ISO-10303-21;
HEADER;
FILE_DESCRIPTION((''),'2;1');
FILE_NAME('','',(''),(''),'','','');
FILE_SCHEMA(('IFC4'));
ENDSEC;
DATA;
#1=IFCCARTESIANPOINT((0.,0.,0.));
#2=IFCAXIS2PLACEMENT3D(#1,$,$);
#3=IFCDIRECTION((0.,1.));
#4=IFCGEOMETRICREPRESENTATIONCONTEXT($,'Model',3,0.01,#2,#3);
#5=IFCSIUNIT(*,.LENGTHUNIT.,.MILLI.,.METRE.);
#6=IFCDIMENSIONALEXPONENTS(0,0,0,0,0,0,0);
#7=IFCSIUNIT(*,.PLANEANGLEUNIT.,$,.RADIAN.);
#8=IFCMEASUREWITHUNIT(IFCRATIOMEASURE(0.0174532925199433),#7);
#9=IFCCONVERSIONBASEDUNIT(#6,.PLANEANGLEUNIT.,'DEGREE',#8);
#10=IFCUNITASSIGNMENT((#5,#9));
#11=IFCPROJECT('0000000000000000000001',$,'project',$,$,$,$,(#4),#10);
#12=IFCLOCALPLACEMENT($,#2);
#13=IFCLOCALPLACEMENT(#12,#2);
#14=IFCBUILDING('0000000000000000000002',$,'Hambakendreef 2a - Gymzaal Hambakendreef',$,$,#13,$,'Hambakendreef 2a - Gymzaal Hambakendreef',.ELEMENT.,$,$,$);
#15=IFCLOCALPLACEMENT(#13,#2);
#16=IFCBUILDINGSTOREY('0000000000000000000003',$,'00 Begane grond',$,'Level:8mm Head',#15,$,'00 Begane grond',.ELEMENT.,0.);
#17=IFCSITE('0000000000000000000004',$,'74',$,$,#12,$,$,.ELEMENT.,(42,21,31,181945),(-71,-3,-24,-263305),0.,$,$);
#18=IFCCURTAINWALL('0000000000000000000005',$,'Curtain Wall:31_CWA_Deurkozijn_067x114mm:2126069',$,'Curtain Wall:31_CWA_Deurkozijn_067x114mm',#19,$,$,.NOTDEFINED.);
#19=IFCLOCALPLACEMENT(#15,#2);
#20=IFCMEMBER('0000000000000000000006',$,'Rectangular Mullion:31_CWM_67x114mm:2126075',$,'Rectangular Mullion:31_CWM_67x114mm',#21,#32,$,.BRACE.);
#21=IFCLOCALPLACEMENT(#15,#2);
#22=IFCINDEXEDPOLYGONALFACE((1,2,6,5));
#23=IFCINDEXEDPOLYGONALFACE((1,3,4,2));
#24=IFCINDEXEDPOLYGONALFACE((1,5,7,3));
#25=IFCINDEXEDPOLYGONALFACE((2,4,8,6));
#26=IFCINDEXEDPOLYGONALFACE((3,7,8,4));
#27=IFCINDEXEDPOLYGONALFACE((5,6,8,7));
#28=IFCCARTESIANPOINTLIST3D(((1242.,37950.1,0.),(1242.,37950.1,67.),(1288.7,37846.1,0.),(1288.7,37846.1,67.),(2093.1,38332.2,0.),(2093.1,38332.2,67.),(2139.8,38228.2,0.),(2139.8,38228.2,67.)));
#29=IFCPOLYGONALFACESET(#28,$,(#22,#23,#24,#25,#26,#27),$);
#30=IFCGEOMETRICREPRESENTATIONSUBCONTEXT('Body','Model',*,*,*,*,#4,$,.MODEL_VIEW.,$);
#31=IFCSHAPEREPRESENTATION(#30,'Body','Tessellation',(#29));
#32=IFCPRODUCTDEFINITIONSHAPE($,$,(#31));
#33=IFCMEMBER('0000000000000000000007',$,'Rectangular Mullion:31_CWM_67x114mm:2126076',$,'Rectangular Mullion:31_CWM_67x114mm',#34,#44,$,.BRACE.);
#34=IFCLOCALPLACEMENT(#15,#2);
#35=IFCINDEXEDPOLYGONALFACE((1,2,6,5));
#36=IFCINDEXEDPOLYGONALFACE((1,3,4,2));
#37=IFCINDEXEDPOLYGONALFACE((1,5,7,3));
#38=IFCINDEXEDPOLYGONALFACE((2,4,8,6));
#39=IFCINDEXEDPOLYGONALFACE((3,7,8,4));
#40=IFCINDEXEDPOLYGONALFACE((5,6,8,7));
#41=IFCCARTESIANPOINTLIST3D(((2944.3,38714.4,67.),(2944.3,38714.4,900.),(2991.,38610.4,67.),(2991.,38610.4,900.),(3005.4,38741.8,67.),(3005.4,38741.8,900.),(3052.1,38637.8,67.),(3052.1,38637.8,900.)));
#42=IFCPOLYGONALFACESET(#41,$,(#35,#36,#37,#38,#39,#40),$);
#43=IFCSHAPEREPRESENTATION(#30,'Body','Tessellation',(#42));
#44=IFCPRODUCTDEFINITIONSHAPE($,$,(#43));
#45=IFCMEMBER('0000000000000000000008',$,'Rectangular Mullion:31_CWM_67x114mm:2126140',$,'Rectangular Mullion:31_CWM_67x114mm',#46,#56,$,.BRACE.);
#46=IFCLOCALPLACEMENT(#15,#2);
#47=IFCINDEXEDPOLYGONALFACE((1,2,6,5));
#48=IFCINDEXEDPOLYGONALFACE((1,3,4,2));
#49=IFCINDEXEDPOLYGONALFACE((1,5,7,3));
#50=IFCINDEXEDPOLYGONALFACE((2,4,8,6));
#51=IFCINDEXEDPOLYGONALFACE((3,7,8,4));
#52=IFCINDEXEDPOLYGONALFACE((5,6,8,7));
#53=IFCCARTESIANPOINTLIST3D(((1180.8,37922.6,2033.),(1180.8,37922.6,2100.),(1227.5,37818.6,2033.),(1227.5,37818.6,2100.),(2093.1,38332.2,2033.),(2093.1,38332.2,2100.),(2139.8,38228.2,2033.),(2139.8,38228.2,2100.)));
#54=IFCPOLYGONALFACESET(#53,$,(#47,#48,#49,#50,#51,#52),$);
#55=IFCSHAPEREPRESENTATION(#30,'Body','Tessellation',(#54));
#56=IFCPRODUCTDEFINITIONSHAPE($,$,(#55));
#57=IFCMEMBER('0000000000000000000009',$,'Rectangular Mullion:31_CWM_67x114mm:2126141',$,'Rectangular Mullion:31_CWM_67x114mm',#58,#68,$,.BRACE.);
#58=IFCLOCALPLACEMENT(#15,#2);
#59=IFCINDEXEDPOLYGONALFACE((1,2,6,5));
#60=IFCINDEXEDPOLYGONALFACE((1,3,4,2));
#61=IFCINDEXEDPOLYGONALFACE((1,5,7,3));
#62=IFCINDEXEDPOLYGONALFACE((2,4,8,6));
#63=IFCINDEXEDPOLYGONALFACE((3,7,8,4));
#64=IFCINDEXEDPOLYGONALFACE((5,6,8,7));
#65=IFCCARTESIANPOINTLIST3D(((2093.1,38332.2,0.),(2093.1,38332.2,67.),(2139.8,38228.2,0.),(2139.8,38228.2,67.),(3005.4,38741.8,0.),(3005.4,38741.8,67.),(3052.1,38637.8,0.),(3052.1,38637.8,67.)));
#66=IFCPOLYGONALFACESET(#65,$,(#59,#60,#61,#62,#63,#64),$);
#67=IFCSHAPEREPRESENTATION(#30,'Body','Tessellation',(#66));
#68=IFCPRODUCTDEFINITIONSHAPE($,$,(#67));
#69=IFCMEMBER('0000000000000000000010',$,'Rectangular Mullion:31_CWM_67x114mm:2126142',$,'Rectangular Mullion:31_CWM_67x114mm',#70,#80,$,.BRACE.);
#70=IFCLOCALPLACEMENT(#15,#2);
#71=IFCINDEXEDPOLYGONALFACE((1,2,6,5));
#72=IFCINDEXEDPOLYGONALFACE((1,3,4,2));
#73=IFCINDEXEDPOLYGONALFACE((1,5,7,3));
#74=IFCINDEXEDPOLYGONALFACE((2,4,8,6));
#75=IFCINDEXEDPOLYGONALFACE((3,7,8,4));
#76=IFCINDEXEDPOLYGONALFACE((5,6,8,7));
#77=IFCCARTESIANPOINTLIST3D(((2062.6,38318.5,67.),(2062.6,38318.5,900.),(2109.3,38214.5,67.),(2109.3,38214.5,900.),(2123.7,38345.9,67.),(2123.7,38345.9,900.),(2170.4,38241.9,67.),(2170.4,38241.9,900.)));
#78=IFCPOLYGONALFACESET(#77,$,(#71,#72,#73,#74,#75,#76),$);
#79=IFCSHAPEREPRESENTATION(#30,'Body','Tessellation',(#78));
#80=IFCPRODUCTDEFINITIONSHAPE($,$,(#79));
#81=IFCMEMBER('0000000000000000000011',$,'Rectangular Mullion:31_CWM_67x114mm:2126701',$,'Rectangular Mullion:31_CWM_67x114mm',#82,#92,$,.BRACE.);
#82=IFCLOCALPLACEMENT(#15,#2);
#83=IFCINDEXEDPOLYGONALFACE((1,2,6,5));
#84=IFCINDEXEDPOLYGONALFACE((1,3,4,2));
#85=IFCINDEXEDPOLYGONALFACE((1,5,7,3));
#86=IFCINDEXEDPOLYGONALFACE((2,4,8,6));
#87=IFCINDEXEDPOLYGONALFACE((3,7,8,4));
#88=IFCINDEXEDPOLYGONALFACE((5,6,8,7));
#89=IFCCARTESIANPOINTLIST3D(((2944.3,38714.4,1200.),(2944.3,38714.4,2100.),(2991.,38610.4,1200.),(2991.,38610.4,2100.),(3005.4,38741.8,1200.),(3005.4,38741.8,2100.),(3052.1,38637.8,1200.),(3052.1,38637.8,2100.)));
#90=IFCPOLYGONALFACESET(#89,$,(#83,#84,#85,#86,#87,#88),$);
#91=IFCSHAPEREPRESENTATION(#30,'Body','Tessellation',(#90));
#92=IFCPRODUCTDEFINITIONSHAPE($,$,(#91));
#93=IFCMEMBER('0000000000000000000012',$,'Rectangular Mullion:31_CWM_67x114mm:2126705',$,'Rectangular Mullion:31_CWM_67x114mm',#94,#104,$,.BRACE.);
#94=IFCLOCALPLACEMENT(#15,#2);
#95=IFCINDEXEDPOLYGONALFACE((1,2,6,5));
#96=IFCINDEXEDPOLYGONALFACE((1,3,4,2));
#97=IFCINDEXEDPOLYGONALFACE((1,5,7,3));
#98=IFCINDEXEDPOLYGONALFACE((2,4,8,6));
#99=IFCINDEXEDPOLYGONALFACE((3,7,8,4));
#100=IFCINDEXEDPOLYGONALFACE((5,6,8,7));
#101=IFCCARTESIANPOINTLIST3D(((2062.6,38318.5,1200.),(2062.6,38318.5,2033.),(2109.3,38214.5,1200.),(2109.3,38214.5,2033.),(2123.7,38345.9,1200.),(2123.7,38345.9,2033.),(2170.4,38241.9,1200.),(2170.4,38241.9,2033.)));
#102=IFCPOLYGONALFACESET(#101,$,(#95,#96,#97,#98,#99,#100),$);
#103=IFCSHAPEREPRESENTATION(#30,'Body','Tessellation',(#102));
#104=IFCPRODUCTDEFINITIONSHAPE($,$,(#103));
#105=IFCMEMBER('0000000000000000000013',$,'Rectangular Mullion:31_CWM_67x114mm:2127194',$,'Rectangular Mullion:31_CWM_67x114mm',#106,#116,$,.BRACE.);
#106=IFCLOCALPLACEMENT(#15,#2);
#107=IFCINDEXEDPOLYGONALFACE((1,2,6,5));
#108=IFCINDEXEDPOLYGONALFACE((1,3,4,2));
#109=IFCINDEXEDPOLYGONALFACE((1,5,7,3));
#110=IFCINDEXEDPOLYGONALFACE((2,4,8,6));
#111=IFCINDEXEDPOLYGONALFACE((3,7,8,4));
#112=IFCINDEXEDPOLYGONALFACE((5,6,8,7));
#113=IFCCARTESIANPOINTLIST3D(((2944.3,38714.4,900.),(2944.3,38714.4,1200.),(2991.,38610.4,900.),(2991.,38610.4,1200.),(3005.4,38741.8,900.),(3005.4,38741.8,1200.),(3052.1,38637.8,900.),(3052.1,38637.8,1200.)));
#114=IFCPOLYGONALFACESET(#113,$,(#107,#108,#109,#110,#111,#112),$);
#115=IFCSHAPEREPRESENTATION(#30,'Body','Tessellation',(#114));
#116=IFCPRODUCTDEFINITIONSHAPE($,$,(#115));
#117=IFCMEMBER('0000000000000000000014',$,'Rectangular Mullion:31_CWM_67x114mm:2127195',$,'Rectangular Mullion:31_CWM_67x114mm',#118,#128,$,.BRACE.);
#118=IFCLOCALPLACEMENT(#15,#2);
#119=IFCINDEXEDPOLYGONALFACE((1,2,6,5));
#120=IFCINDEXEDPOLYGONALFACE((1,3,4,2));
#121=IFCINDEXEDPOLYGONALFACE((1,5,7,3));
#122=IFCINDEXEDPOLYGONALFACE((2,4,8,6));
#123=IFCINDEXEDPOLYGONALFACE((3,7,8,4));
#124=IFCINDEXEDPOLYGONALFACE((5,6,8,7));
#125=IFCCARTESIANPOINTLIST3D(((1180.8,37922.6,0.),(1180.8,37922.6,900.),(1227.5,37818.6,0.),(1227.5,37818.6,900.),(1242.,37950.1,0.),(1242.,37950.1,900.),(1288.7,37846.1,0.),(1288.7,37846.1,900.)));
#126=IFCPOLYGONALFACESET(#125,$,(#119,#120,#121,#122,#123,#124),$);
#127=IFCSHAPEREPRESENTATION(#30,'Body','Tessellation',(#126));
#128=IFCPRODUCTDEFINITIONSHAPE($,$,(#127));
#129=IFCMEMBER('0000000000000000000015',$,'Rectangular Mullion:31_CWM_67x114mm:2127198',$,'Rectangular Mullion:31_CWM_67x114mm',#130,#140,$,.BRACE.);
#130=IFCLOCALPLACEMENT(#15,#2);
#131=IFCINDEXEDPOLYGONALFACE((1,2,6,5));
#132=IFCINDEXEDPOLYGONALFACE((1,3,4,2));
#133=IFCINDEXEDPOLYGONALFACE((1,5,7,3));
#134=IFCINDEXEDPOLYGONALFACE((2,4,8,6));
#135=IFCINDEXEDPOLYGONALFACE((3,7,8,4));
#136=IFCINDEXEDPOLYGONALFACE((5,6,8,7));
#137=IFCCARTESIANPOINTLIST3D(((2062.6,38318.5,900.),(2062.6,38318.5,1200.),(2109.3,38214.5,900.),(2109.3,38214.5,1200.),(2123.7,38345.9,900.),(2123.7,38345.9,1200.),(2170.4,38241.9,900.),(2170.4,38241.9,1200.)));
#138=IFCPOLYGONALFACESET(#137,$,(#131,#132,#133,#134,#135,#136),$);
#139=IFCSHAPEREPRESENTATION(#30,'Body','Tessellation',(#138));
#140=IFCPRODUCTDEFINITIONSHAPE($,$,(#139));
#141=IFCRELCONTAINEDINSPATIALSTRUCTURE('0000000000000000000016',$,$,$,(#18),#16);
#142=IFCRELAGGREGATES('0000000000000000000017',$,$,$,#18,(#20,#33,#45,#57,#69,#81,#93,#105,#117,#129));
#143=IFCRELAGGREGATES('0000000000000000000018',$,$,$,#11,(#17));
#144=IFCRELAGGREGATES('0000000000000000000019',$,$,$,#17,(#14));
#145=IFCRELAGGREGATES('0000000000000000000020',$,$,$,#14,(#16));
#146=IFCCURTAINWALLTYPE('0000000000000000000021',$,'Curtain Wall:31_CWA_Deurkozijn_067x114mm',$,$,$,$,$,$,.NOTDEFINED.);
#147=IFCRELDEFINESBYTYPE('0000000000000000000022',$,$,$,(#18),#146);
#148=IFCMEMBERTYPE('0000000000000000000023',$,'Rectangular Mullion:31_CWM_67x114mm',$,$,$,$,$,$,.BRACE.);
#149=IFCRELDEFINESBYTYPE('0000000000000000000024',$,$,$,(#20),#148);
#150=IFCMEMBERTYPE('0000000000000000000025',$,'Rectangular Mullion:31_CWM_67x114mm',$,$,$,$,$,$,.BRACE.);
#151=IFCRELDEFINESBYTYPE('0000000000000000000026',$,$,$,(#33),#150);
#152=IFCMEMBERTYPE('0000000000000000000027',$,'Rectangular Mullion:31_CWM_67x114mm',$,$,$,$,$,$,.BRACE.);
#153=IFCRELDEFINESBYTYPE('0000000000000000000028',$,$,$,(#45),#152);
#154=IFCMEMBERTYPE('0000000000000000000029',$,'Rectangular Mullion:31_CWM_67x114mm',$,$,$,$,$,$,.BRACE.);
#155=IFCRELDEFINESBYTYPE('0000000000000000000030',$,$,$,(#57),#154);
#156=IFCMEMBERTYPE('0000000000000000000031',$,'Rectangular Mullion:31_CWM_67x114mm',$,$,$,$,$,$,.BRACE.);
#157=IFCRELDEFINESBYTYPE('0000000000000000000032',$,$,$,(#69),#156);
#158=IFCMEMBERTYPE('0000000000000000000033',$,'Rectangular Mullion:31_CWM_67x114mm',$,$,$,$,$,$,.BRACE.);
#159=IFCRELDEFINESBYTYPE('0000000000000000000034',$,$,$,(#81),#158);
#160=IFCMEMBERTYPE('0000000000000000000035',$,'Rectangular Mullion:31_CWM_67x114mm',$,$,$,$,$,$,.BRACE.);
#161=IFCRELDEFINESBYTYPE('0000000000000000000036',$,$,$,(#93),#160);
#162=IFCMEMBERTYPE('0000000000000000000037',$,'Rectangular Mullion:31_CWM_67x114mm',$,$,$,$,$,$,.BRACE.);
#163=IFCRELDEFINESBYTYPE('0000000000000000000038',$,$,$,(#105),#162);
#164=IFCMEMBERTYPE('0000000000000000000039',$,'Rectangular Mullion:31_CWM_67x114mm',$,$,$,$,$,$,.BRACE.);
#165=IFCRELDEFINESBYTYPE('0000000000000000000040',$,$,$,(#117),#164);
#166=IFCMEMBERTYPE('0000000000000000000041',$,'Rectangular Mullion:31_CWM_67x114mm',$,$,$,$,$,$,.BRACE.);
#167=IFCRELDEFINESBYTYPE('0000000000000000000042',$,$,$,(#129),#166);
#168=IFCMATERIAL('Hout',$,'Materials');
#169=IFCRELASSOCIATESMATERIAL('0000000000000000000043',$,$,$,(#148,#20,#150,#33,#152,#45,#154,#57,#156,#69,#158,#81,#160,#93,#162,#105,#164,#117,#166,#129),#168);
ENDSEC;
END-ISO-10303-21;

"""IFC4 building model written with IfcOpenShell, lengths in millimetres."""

from ifc_helpers import new_model, entity, si_unit, converted_unit, direction, frame, origin, place, context, subcontext, project, spatial, indexed_curve, outline, extrude, source, transform, mapped, material, type_object, type_shapes, element, aggregate, save


model = new_model("IFC4")

# Units and contexts
model_context = context("Model", 3, precision=0.01, world=origin(), true_north=direction((0.0, 1.0)))
body_context = subcontext(model_context, "Body", "Model", "MODEL_VIEW")
ifc_project = project(units=[si_unit("LENGTHUNIT", "METRE", prefix="MILLI"), converted_unit("PLANEANGLEUNIT", "DEGREE", entity("IfcRatioMeasure", 0.0174532925199433), si_unit("PLANEANGLEUNIT", "RADIAN"), dimensions=[0, 0, 0, 0, 0, 0, 0])], contexts=[model_context])

# Site, building, storey
site_placement = place(None, origin())
site = spatial("IfcSite", under=ifc_project, at=site_placement, Name="74", CompositionType="ELEMENT", RefLatitude=(42, 21, 31, 181945), RefLongitude=(-71, -3, -24, -263305), RefElevation=0.0)
building_placement = place(site_placement, origin())
building = spatial("IfcBuilding", under=site, at=building_placement, Name="Hambakendreef 2a - Gymzaal Hambakendreef", LongName="Hambakendreef 2a - Gymzaal Hambakendreef", CompositionType="ELEMENT")
storey_placement = place(building_placement, origin())
storey = spatial("IfcBuildingStorey", under=building, at=storey_placement, Name="00 Begane grond", ObjectType="Level:8mm Head", LongName="00 Begane grond", CompositionType="ELEMENT", Elevation=0.0)

# Curtain wall, members
ifc_material_1 = material(Name="Hout", Category="Materials")
curtain_wall_type_1 = type_object("IfcCurtainWallType", Name="Curtain Wall:31_CWA_Deurkozijn_067x114mm", PredefinedType="NOTDEFINED")
curtain_wall_1_placement = place(storey_placement, origin())
curtain_wall_1 = element("IfcCurtainWall", 1, at=curtain_wall_1_placement, inside=storey, type_object=curtain_wall_type_1, Name="Curtain Wall:31_CWA_Deurkozijn_067x114mm:2126069", ObjectType="Curtain Wall:31_CWA_Deurkozijn_067x114mm", PredefinedType="NOTDEFINED")
member_type_1 = type_object("IfcMemberType", Name="Rectangular Mullion:31_CWM_67x114mm", PredefinedType="BRACE", material=ifc_material_1)
shared_shape_1 = source(origin(), body_context, "Body", "SweptSolid", [
    extrude(outline(indexed_curve([(-57.0, -33.5), (57.0, -33.5), (57.0, 33.5), (-57.0, 33.5), (-57.0, -33.5)], self_intersect=False)), frame((-33.5, 0.0, -933.0), z_axis=(0.0, 0.0, 1.0), x_axis=(0.0, -1.0, 0.0)), (0.0, 0.0, 1.0), 933.0),
])
type_shapes(member_type_1, [shared_shape_1])
member_1_placement = place(storey_placement, frame((1265.3, 37898.1, 0.0), z_axis=(-0.91227, -0.40959, 0.0), x_axis=(0.0, 0.0, -1.0)))
member_1 = element("IfcMember", 2, at=member_1_placement, type_object=member_type_1, material=ifc_material_1, Name="Rectangular Mullion:31_CWM_67x114mm:2126075", ObjectType="Rectangular Mullion:31_CWM_67x114mm", PredefinedType="BRACE", context=body_context, shape_type="MappedRepresentation", body=[
    mapped(shared_shape_1, transform((0.0, 0.0, 0.0), scale=1.0)),
])
member_type_2 = type_object("IfcMemberType", Name="Rectangular Mullion:31_CWM_67x114mm", PredefinedType="BRACE", material=ifc_material_1)
shared_shape_2 = source(origin(), body_context, "Body", "SweptSolid", [
    extrude(outline(indexed_curve([(-57.0, -33.5), (57.0, -33.5), (57.0, 33.5), (-57.0, 33.5), (-57.0, -33.5)], self_intersect=False)), frame((-33.5, 0.0, -833.0), z_axis=(0.0, 0.0, 1.0), x_axis=(0.0, -1.0, 0.0)), (0.0, 0.0, 1.0), 833.0),
])
type_shapes(member_type_2, [shared_shape_2])
member_2_placement = place(storey_placement, frame((3028.7, 38689.8, 67.0), z_axis=(0.0, 0.0, -1.0), x_axis=(0.91227, 0.40959, 0.0)))
member_2 = element("IfcMember", 3, at=member_2_placement, type_object=member_type_2, material=ifc_material_1, Name="Rectangular Mullion:31_CWM_67x114mm:2126076", ObjectType="Rectangular Mullion:31_CWM_67x114mm", PredefinedType="BRACE", context=body_context, shape_type="MappedRepresentation", body=[
    mapped(shared_shape_2, transform((0.0, 0.0, 0.0), scale=1.0)),
])
member_type_3 = type_object("IfcMemberType", Name="Rectangular Mullion:31_CWM_67x114mm", PredefinedType="BRACE", material=ifc_material_1)
shared_shape_3 = source(origin(), body_context, "Body", "SweptSolid", [
    extrude(outline(indexed_curve([(-57.0, -33.5), (57.0, -33.5), (57.0, 33.5), (-57.0, 33.5), (-57.0, -33.5)], self_intersect=False)), frame((-33.5, 0.0, -1000.0), z_axis=(0.0, 0.0, 1.0), x_axis=(0.0, -1.0, 0.0)), (0.0, 0.0, 1.0), 1000.0),
])
type_shapes(member_type_3, [shared_shape_3])
member_3_placement = place(storey_placement, frame((2116.5, 38280.2, 2100.0), z_axis=(0.91227, 0.40959, 0.0), x_axis=(0.0, 0.0, 1.0)))
member_3 = element("IfcMember", 4, at=member_3_placement, type_object=member_type_3, material=ifc_material_1, Name="Rectangular Mullion:31_CWM_67x114mm:2126140", ObjectType="Rectangular Mullion:31_CWM_67x114mm", PredefinedType="BRACE", context=body_context, shape_type="MappedRepresentation", body=[
    mapped(shared_shape_3, transform((0.0, 0.0, 0.0), scale=1.0)),
])
member_type_4 = type_object("IfcMemberType", Name="Rectangular Mullion:31_CWM_67x114mm", PredefinedType="BRACE", material=ifc_material_1)
shared_shape_4 = source(origin(), body_context, "Body", "SweptSolid", [
    extrude(outline(indexed_curve([(-57.0, -33.5), (57.0, -33.5), (57.0, 33.5), (-57.0, 33.5), (-57.0, -33.5)], self_intersect=False)), frame((-33.5, 0.0, -1000.0), z_axis=(0.0, 0.0, 1.0), x_axis=(0.0, -1.0, 0.0)), (0.0, 0.0, 1.0), 1000.0),
])
type_shapes(member_type_4, [shared_shape_4])
member_4_placement = place(storey_placement, frame((2116.5, 38280.2, 0.0), z_axis=(-0.91227, -0.40959, 0.0), x_axis=(0.0, 0.0, -1.0)))
member_4 = element("IfcMember", 5, at=member_4_placement, type_object=member_type_4, material=ifc_material_1, Name="Rectangular Mullion:31_CWM_67x114mm:2126141", ObjectType="Rectangular Mullion:31_CWM_67x114mm", PredefinedType="BRACE", context=body_context, shape_type="MappedRepresentation", body=[
    mapped(shared_shape_4, transform((0.0, 0.0, 0.0), scale=1.0)),
])
member_type_5 = type_object("IfcMemberType", Name="Rectangular Mullion:31_CWM_67x114mm", PredefinedType="BRACE", material=ifc_material_1)
shared_shape_5 = source(origin(), body_context, "Body", "SweptSolid", [
    extrude(outline(indexed_curve([(-57.0, -33.5), (57.0, -33.5), (57.0, 33.5), (-57.0, 33.5), (-57.0, -33.5)], self_intersect=False)), frame((0.0, 0.0, -833.0), z_axis=(0.0, 0.0, 1.0), x_axis=(0.0, -1.0, 0.0)), (0.0, 0.0, 1.0), 833.0),
])
type_shapes(member_type_5, [shared_shape_5])
member_5_placement = place(storey_placement, frame((2116.5, 38280.2, 67.0), z_axis=(0.0, 0.0, -1.0), x_axis=(0.91227, 0.40959, 0.0)))
member_5 = element("IfcMember", 6, at=member_5_placement, type_object=member_type_5, material=ifc_material_1, Name="Rectangular Mullion:31_CWM_67x114mm:2126142", ObjectType="Rectangular Mullion:31_CWM_67x114mm", PredefinedType="BRACE", context=body_context, shape_type="MappedRepresentation", body=[
    mapped(shared_shape_5, transform((0.0, 0.0, 0.0), scale=1.0)),
])
member_type_6 = type_object("IfcMemberType", Name="Rectangular Mullion:31_CWM_67x114mm", PredefinedType="BRACE", material=ifc_material_1)
shared_shape_6 = source(origin(), body_context, "Body", "SweptSolid", [
    extrude(outline(indexed_curve([(-57.0, -33.5), (57.0, -33.5), (57.0, 33.5), (-57.0, 33.5), (-57.0, -33.5)], self_intersect=False)), frame((-33.5, 0.0, -900.0), z_axis=(0.0, 0.0, 1.0), x_axis=(0.0, -1.0, 0.0)), (0.0, 0.0, 1.0), 900.0),
])
type_shapes(member_type_6, [shared_shape_6])
member_6_placement = place(storey_placement, frame((3028.7, 38689.8, 1200.0), z_axis=(0.0, 0.0, -1.0), x_axis=(0.91227, 0.40959, 0.0)))
member_6 = element("IfcMember", 7, at=member_6_placement, type_object=member_type_6, material=ifc_material_1, Name="Rectangular Mullion:31_CWM_67x114mm:2126701", ObjectType="Rectangular Mullion:31_CWM_67x114mm", PredefinedType="BRACE", context=body_context, shape_type="MappedRepresentation", body=[
    mapped(shared_shape_6, transform((0.0, 0.0, 0.0), scale=1.0)),
])
member_type_7 = type_object("IfcMemberType", Name="Rectangular Mullion:31_CWM_67x114mm", PredefinedType="BRACE", material=ifc_material_1)
shared_shape_7 = source(origin(), body_context, "Body", "SweptSolid", [
    extrude(outline(indexed_curve([(-57.0, -33.5), (57.0, -33.5), (57.0, 33.5), (-57.0, 33.5), (-57.0, -33.5)], self_intersect=False)), frame((0.0, 0.0, -833.0), z_axis=(0.0, 0.0, 1.0), x_axis=(0.0, -1.0, 0.0)), (0.0, 0.0, 1.0), 833.0),
])
type_shapes(member_type_7, [shared_shape_7])
member_7_placement = place(storey_placement, frame((2116.5, 38280.2, 1200.0), z_axis=(0.0, 0.0, -1.0), x_axis=(0.91227, 0.40959, 0.0)))
member_7 = element("IfcMember", 8, at=member_7_placement, type_object=member_type_7, material=ifc_material_1, Name="Rectangular Mullion:31_CWM_67x114mm:2126705", ObjectType="Rectangular Mullion:31_CWM_67x114mm", PredefinedType="BRACE", context=body_context, shape_type="MappedRepresentation", body=[
    mapped(shared_shape_7, transform((0.0, 0.0, 0.0), scale=1.0)),
])
member_type_8 = type_object("IfcMemberType", Name="Rectangular Mullion:31_CWM_67x114mm", PredefinedType="BRACE", material=ifc_material_1)
shared_shape_8 = source(origin(), body_context, "Body", "SweptSolid", [
    extrude(outline(indexed_curve([(-57.0, -33.5), (57.0, -33.5), (57.0, 33.5), (-57.0, 33.5), (-57.0, -33.5)], self_intersect=False)), frame((-33.5, 0.0, -300.0), z_axis=(0.0, 0.0, 1.0), x_axis=(0.0, -1.0, 0.0)), (0.0, 0.0, 1.0), 300.0),
])
type_shapes(member_type_8, [shared_shape_8])
member_8_placement = place(storey_placement, frame((3028.7, 38689.8, 900.0), z_axis=(0.0, 0.0, -1.0), x_axis=(0.91227, 0.40959, 0.0)))
member_8 = element("IfcMember", 9, at=member_8_placement, type_object=member_type_8, material=ifc_material_1, Name="Rectangular Mullion:31_CWM_67x114mm:2127194", ObjectType="Rectangular Mullion:31_CWM_67x114mm", PredefinedType="BRACE", context=body_context, shape_type="MappedRepresentation", body=[
    mapped(shared_shape_8, transform((0.0, 0.0, 0.0), scale=1.0)),
])
member_type_9 = type_object("IfcMemberType", Name="Rectangular Mullion:31_CWM_67x114mm", PredefinedType="BRACE", material=ifc_material_1)
shared_shape_9 = source(origin(), body_context, "Body", "SweptSolid", [
    extrude(outline(indexed_curve([(-57.0, -33.5), (57.0, -33.5), (57.0, 33.5), (-57.0, 33.5), (-57.0, -33.5)], self_intersect=False)), frame((-33.5, 0.0, -900.0), z_axis=(0.0, 0.0, 1.0), x_axis=(0.0, -1.0, 0.0)), (0.0, 0.0, 1.0), 900.0),
])
type_shapes(member_type_9, [shared_shape_9])
member_9_placement = place(storey_placement, frame((1204.2, 37870.6, 900.0), z_axis=(0.0, 0.0, 1.0), x_axis=(-0.91227, -0.40959, 0.0)))
member_9 = element("IfcMember", 10, at=member_9_placement, type_object=member_type_9, material=ifc_material_1, Name="Rectangular Mullion:31_CWM_67x114mm:2127195", ObjectType="Rectangular Mullion:31_CWM_67x114mm", PredefinedType="BRACE", context=body_context, shape_type="MappedRepresentation", body=[
    mapped(shared_shape_9, transform((0.0, 0.0, 0.0), scale=1.0)),
])
member_type_10 = type_object("IfcMemberType", Name="Rectangular Mullion:31_CWM_67x114mm", PredefinedType="BRACE", material=ifc_material_1)
shared_shape_10 = source(origin(), body_context, "Body", "SweptSolid", [
    extrude(outline(indexed_curve([(-57.0, -33.5), (57.0, -33.5), (57.0, 33.5), (-57.0, 33.5), (-57.0, -33.5)], self_intersect=False)), frame((0.0, 0.0, -300.0), z_axis=(0.0, 0.0, 1.0), x_axis=(0.0, -1.0, 0.0)), (0.0, 0.0, 1.0), 300.0),
])
type_shapes(member_type_10, [shared_shape_10])
member_10_placement = place(storey_placement, frame((2116.5, 38280.2, 900.0), z_axis=(0.0, 0.0, -1.0), x_axis=(0.91227, 0.40959, 0.0)))
member_10 = element("IfcMember", 11, at=member_10_placement, type_object=member_type_10, material=ifc_material_1, Name="Rectangular Mullion:31_CWM_67x114mm:2127198", ObjectType="Rectangular Mullion:31_CWM_67x114mm", PredefinedType="BRACE", context=body_context, shape_type="MappedRepresentation", body=[
    mapped(shared_shape_10, transform((0.0, 0.0, 0.0), scale=1.0)),
])

aggregate(curtain_wall_1, [member_1, member_2, member_3, member_4, member_5, member_6, member_7, member_8, member_9, member_10])

save(model, "model.ifc")
